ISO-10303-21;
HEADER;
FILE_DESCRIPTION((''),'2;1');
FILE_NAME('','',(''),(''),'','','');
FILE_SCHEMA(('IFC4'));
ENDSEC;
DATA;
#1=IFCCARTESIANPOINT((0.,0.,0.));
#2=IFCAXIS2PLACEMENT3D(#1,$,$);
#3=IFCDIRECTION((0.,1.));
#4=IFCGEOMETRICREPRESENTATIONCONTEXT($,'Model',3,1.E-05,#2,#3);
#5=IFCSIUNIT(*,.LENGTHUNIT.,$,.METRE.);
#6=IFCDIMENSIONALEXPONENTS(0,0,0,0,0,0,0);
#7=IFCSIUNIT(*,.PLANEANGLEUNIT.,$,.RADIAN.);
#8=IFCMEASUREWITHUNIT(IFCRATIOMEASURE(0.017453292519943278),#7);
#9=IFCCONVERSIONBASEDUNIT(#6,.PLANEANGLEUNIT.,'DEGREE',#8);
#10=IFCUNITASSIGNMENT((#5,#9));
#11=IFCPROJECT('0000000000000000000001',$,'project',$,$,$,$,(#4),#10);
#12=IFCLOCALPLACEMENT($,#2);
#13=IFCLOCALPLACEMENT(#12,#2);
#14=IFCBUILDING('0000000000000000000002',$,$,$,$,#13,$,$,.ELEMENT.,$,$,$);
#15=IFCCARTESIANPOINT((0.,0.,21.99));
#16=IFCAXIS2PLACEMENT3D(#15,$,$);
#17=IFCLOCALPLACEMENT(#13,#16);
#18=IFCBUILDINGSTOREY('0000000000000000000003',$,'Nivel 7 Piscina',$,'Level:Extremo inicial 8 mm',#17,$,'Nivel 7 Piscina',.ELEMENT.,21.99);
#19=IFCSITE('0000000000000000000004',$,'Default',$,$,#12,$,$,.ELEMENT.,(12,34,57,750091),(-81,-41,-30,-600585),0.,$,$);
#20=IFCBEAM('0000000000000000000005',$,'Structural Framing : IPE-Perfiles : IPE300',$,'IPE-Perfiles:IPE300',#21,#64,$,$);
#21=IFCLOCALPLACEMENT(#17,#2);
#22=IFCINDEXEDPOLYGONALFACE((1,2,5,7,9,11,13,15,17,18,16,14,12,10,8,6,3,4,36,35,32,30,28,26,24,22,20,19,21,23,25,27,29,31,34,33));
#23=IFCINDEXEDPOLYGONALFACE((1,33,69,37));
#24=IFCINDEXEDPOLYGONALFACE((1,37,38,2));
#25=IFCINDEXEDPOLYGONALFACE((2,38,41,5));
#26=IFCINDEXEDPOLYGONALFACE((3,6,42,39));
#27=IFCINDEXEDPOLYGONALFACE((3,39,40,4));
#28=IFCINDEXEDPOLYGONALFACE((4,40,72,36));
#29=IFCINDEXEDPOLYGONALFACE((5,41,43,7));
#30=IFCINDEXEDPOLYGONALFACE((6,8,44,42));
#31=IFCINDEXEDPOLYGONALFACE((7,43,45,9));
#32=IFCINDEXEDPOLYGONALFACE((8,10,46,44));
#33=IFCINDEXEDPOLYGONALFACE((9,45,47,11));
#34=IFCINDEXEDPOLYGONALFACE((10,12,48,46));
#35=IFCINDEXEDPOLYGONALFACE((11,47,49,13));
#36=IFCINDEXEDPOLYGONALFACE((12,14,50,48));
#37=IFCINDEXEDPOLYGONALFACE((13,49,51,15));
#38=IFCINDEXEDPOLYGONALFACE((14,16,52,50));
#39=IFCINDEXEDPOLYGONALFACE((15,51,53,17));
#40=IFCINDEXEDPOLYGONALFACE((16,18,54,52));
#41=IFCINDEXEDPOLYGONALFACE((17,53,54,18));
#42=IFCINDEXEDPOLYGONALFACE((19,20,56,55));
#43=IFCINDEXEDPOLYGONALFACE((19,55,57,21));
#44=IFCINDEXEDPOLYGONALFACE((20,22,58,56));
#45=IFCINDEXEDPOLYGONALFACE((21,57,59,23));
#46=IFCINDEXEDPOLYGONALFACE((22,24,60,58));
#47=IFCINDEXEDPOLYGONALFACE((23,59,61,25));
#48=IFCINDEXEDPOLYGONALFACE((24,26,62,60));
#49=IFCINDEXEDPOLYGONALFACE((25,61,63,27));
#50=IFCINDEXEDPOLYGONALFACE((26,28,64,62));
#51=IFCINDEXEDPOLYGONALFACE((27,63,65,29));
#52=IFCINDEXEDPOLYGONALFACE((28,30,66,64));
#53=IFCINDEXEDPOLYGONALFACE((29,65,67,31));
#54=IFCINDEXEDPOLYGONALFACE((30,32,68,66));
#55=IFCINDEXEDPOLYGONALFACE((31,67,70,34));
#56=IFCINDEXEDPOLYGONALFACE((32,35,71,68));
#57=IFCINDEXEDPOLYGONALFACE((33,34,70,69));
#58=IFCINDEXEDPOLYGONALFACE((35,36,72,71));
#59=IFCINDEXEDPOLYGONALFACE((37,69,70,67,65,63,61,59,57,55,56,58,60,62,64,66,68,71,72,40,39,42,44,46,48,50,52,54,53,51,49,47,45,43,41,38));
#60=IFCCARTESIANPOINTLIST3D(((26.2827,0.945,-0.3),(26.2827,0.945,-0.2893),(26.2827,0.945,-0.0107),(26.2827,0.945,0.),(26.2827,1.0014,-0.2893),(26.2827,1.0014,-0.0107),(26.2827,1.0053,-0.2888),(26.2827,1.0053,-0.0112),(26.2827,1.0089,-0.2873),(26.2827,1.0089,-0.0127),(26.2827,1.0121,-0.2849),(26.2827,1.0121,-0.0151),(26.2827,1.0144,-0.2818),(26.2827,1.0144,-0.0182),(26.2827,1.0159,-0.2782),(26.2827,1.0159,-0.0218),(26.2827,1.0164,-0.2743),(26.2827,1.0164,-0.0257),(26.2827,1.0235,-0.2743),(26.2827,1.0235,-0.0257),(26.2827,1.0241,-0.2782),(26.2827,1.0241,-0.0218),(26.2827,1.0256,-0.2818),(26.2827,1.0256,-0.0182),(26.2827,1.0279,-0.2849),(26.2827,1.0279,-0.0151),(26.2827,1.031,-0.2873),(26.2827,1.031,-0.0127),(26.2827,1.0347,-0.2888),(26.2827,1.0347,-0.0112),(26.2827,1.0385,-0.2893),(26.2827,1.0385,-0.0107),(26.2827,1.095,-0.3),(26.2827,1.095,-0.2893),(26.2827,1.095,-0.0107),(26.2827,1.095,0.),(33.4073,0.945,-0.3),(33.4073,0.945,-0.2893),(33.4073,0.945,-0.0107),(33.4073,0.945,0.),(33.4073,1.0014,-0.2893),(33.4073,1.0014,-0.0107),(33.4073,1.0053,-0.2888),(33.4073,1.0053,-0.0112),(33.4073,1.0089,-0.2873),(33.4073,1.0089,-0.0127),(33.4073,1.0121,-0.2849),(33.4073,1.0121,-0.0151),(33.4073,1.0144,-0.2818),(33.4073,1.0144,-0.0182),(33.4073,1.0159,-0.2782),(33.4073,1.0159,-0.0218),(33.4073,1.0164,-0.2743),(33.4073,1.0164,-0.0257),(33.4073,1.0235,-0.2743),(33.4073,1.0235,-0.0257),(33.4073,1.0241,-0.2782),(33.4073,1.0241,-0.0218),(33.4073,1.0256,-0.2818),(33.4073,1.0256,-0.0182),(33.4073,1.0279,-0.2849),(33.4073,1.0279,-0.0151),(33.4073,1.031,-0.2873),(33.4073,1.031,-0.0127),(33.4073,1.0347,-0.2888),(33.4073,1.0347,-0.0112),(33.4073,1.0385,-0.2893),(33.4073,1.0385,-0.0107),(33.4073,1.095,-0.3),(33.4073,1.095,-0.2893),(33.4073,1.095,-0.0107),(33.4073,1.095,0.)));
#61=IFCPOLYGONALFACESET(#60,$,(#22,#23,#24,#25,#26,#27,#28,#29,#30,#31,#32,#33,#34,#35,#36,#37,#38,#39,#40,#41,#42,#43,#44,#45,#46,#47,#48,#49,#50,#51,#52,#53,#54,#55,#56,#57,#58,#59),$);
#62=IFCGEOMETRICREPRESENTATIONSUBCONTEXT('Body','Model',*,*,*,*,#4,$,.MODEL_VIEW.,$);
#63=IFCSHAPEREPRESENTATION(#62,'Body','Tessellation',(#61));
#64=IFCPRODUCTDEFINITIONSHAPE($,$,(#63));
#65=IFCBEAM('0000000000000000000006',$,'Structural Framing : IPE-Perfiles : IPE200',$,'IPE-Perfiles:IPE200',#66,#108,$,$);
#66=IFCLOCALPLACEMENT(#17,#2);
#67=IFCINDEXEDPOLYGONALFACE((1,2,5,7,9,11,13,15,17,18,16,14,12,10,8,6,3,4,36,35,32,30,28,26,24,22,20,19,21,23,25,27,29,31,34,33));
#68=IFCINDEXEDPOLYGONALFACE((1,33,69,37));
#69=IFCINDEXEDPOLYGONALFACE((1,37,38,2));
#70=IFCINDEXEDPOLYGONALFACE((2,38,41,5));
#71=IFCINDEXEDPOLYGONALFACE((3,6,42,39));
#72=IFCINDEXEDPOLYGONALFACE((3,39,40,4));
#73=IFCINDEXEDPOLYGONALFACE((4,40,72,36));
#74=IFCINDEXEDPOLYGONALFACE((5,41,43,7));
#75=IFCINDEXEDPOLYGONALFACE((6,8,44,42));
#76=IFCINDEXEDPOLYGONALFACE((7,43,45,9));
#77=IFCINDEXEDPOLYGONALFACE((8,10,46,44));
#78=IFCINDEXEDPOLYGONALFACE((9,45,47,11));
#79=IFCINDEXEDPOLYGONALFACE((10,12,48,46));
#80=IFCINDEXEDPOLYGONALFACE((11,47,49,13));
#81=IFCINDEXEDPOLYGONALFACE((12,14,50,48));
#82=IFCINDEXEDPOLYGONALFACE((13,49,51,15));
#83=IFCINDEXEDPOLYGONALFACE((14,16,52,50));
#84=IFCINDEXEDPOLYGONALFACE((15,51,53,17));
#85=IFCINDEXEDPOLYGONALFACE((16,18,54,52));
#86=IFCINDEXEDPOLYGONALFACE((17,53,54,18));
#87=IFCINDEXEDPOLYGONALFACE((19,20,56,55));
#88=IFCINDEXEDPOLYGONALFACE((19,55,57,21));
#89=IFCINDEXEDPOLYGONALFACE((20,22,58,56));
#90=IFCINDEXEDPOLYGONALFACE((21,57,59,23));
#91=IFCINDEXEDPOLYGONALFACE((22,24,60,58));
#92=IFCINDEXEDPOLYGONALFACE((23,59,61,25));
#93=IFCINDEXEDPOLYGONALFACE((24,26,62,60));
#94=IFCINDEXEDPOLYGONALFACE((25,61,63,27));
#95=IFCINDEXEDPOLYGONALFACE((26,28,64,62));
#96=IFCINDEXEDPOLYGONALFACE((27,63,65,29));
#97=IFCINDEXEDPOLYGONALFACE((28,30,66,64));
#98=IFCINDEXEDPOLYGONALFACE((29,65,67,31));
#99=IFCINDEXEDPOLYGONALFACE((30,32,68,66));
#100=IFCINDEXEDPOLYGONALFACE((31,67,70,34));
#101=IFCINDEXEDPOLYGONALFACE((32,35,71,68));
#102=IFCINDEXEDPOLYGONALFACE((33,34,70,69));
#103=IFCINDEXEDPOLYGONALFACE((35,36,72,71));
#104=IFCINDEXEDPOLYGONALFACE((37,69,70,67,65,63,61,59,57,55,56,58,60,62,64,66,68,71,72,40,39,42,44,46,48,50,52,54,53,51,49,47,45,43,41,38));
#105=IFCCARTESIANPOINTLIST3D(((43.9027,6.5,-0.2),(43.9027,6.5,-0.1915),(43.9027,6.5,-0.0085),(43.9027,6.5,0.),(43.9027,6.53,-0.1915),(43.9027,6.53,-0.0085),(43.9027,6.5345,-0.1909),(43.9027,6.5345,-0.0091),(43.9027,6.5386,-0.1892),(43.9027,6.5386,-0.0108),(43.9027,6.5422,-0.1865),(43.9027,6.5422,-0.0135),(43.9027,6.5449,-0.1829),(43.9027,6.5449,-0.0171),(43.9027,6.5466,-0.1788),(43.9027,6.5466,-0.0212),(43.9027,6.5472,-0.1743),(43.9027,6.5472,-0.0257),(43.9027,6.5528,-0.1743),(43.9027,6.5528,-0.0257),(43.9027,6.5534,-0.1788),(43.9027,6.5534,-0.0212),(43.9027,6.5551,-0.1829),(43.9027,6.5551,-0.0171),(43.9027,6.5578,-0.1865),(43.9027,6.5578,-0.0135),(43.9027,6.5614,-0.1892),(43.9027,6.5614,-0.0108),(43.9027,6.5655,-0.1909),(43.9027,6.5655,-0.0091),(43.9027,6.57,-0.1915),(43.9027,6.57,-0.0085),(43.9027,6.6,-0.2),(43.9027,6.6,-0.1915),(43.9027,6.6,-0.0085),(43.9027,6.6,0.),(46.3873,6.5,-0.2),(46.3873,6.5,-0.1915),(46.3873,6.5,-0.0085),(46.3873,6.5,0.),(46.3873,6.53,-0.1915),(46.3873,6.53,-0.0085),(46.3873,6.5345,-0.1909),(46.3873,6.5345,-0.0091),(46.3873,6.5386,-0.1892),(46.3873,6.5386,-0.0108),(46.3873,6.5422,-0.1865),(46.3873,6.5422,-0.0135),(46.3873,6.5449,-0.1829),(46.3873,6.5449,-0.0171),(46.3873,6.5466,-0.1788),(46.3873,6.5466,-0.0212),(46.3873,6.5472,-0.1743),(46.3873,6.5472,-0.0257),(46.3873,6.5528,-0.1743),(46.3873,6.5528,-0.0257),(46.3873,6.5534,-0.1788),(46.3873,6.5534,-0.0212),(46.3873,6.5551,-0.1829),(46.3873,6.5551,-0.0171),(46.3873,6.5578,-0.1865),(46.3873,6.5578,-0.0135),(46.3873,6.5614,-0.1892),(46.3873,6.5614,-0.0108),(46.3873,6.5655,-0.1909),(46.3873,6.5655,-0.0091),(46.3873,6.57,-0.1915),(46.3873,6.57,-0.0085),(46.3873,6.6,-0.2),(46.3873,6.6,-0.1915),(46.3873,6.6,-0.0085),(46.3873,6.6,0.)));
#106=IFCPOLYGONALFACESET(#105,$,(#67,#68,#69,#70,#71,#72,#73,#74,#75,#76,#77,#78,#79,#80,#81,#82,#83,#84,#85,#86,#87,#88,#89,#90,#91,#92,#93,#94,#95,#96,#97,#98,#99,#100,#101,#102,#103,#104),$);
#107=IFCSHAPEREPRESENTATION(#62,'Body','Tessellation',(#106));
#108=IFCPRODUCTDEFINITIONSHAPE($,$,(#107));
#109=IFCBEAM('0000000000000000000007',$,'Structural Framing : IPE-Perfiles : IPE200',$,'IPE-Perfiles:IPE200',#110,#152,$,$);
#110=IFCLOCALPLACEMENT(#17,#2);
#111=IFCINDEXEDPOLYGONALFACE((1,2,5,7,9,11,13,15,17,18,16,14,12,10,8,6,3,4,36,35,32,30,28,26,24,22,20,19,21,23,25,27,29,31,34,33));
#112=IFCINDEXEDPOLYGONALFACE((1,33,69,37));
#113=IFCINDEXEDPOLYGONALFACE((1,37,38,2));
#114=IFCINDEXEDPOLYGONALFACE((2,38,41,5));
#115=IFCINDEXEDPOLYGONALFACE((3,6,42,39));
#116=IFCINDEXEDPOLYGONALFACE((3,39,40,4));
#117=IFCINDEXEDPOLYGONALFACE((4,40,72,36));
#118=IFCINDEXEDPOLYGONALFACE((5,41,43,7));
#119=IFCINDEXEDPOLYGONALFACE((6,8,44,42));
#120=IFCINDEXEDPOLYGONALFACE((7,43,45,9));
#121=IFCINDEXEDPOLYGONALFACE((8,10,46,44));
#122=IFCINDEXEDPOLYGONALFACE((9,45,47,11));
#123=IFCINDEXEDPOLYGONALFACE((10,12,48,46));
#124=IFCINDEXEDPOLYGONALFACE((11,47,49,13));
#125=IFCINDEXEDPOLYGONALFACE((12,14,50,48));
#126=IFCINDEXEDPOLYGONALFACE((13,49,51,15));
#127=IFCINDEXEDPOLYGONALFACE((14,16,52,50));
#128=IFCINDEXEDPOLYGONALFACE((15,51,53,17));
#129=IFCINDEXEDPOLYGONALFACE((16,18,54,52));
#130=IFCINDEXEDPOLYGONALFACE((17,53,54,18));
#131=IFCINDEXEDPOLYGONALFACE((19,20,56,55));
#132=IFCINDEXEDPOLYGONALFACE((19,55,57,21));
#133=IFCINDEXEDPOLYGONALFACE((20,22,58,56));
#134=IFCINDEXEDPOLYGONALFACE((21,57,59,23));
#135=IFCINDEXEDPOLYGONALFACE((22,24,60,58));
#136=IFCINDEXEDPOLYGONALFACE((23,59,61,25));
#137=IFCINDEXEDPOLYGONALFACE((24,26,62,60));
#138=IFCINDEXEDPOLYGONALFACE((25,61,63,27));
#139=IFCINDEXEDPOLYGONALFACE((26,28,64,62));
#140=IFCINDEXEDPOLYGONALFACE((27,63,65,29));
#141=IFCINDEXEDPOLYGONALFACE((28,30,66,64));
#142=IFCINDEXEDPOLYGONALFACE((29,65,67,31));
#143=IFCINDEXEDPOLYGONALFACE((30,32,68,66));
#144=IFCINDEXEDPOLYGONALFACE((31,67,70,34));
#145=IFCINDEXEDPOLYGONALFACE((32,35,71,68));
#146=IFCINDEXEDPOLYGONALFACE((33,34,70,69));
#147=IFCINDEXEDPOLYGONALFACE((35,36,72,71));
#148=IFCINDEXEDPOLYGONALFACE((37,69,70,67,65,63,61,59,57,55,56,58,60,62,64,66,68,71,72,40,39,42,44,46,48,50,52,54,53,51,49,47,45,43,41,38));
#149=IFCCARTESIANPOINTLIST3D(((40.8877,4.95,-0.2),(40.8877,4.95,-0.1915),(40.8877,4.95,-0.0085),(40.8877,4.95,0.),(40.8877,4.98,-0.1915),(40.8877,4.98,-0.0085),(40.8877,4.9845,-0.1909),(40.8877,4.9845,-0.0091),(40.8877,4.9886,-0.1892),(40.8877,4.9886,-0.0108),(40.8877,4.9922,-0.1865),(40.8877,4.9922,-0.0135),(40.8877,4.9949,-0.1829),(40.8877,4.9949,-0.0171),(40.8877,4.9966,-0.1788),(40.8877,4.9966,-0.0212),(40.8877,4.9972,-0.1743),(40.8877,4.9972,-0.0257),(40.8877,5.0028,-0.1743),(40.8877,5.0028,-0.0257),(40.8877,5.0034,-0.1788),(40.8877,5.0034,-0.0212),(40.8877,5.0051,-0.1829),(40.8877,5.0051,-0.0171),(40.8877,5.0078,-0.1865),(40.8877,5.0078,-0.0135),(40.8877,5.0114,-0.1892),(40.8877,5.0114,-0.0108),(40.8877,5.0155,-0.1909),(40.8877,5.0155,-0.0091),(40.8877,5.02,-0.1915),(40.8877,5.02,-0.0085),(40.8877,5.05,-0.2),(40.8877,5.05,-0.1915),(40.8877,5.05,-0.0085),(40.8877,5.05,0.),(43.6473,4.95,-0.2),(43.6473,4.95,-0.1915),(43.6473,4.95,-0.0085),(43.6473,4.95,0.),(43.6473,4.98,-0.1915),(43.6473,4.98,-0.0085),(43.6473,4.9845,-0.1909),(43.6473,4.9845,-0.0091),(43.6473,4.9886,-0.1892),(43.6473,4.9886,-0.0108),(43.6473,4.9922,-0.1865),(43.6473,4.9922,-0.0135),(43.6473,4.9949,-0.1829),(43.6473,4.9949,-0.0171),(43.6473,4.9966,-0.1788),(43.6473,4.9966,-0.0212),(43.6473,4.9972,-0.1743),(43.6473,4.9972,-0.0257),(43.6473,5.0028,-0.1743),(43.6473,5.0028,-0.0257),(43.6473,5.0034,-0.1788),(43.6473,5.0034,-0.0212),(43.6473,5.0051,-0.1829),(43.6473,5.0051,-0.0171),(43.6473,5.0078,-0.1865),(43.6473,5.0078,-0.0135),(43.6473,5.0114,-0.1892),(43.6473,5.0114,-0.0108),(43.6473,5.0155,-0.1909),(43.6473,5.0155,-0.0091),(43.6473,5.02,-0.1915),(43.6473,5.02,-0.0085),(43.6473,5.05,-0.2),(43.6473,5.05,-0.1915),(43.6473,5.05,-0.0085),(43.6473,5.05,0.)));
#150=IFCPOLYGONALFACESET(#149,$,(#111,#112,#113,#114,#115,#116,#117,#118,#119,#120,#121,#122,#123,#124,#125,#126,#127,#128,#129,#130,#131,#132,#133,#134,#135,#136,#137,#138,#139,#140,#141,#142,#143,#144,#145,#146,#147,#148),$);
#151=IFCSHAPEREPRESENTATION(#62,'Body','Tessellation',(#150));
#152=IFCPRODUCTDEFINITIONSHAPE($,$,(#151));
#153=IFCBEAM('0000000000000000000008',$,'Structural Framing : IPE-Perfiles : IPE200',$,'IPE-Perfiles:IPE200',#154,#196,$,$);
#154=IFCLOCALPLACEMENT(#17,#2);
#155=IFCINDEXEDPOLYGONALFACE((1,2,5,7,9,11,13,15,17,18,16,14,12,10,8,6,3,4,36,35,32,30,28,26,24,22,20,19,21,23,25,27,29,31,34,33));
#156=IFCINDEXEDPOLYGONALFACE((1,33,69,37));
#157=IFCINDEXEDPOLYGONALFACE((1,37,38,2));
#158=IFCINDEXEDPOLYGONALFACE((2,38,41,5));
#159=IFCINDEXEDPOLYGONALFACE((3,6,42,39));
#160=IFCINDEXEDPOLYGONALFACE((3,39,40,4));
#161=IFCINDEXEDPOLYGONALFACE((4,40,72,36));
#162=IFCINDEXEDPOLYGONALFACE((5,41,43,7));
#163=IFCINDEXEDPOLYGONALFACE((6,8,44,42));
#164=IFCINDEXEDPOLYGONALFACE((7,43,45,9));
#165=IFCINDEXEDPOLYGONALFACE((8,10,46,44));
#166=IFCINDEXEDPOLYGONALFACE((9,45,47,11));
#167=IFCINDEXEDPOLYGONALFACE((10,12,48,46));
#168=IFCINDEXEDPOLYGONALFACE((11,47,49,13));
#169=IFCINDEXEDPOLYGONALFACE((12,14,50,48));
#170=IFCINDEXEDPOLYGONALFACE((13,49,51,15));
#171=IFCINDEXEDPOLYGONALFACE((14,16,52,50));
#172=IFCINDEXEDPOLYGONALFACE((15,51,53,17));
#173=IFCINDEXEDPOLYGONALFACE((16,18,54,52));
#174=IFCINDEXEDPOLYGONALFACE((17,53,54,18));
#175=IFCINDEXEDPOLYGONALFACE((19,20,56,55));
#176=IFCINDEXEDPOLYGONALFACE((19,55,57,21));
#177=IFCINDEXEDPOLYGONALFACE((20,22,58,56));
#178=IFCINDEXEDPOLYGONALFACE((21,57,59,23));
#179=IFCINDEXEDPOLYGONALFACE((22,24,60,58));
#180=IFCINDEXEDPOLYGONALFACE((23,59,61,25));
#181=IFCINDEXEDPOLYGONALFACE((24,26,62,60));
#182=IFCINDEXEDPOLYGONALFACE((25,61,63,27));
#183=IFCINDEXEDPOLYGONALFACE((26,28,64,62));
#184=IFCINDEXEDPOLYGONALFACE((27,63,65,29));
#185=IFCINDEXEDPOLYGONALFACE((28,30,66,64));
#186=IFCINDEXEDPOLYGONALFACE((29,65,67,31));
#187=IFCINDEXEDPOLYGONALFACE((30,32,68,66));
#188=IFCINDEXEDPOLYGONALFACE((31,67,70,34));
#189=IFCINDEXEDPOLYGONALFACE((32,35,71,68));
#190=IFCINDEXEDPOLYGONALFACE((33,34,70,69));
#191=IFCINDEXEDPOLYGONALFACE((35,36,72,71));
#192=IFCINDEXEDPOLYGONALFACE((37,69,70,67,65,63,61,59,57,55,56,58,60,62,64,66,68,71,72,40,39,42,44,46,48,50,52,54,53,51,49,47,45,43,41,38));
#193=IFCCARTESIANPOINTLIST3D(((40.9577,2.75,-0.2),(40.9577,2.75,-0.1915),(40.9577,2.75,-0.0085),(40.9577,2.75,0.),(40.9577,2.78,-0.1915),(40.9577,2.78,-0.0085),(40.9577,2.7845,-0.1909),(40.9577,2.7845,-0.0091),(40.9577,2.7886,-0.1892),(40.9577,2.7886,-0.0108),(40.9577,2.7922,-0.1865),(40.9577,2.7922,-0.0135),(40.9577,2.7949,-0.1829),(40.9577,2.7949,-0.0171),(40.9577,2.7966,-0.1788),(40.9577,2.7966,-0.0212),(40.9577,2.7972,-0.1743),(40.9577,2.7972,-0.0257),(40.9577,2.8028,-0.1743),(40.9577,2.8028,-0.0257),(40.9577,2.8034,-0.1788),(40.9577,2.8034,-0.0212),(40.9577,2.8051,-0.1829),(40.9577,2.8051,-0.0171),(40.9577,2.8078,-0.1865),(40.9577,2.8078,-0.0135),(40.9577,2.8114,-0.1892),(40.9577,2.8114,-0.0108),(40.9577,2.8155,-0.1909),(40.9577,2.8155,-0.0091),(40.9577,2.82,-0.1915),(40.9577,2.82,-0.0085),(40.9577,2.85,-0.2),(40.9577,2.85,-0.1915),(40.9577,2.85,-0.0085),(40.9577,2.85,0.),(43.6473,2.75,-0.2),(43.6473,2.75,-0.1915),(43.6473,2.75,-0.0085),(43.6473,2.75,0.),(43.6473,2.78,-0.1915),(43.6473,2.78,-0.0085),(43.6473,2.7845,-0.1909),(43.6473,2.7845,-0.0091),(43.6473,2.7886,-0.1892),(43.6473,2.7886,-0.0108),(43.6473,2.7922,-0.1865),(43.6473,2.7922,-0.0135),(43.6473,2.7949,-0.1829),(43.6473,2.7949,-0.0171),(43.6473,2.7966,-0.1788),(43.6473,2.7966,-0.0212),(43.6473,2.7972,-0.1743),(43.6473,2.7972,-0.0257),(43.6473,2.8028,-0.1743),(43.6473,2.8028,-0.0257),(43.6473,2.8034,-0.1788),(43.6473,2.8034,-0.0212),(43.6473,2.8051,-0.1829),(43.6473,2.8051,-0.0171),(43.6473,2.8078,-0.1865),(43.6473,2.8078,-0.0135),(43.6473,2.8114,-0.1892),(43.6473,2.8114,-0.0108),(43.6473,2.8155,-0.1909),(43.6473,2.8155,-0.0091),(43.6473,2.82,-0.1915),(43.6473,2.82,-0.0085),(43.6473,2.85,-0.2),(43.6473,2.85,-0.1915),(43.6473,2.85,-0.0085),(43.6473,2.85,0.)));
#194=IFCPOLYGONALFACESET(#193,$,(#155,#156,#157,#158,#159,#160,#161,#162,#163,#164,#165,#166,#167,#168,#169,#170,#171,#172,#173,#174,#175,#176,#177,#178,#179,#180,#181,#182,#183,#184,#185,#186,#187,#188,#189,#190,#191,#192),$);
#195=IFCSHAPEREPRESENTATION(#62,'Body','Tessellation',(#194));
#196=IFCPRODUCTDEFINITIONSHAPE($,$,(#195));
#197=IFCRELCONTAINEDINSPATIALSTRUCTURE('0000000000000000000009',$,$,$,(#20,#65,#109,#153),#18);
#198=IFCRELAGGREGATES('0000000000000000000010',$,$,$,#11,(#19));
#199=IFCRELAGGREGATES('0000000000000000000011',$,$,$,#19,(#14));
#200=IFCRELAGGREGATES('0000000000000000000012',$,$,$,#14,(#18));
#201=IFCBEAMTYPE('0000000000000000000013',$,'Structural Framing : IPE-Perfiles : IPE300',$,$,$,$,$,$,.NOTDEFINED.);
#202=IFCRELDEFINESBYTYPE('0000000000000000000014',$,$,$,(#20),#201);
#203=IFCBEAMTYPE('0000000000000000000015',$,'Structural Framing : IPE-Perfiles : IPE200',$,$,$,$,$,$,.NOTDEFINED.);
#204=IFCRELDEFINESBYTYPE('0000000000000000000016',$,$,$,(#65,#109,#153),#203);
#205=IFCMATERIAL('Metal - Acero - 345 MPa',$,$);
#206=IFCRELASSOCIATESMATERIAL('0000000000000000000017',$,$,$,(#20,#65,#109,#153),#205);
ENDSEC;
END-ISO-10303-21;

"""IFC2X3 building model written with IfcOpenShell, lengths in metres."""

from ifc_helpers import new_model, entity, si_unit, converted_unit, direction, frame, frame_2d, origin, place, context, subcontext, project, spatial, i_section, extrude, material, type_object, element, save


model = new_model("IFC2X3")

# Units and contexts
model_context = context("Model", 3, precision=1e-05, world=origin(), true_north=direction((0.0, 1.0)))
body_context = subcontext(model_context, "Body", "Model", "MODEL_VIEW")
ifc_project = project(units=[si_unit("LENGTHUNIT", "METRE"), converted_unit("PLANEANGLEUNIT", "DEGREE", entity("IfcRatioMeasure", 0.017453292519943278), si_unit("PLANEANGLEUNIT", "RADIAN"), dimensions=[0, 0, 0, 0, 0, 0, 0])], contexts=[model_context])

# Site, building, storey
site_placement = place(None, origin())
site = spatial("IfcSite", under=ifc_project, at=site_placement, Name="Default", CompositionType="ELEMENT", RefLatitude=(12, 34, 57, 750091), RefLongitude=(-81, -41, -30, -600585), RefElevation=0.0)
building_placement = place(site_placement, origin())
building = spatial("IfcBuilding", under=site, at=building_placement, CompositionType="ELEMENT")
storey_placement = place(building_placement, frame((0.0, 0.0, 21.99)))
storey = spatial("IfcBuildingStorey", under=building, at=storey_placement, Name="Nivel 7 Piscina", ObjectType="Level:Extremo inicial 8 mm", LongName="Nivel 7 Piscina", CompositionType="ELEMENT", Elevation=21.99)

# Shared definitions
ifc_material = material(Name="Metal - Acero - 345 MPa")

# Beams
beam_type_1 = type_object("IfcBeamType", Name="Structural Framing : IPE-Perfiles : IPE300", PredefinedType="NOTDEFINED")
beam_1_placement = place(storey_placement, frame((26.195, 1.02, 0.0)))
element("IfcBeam", 1, at=beam_1_placement, inside=storey, type_object=beam_type_1, material=ifc_material, Name="Structural Framing : IPE-Perfiles : IPE300", ObjectType="IPE-Perfiles:IPE300", context=body_context, shape_type="SweptSolid", body=[
    extrude(i_section(OverallWidth=0.15, OverallDepth=0.3, WebThickness=0.0071, FlangeThickness=0.0107, FilletRadius=0.015, at=frame_2d((0.0, 0.0), x_axis=(0.0, 1.0))), frame((0.0877, 0.0, -0.15), z_axis=(1.0, 0.0, 0.0), x_axis=(0.0, 0.0, -1.0)), (0.0, 0.0, 1.0), 7.1246),
])
beam_type_2 = type_object("IfcBeamType", Name="Structural Framing : IPE-Perfiles : IPE200", PredefinedType="NOTDEFINED")
beam_2_placement = place(storey_placement, frame((43.74, 6.55, 0.0)))
element("IfcBeam", 2, at=beam_2_placement, inside=storey, type_object=beam_type_2, material=ifc_material, Name="Structural Framing : IPE-Perfiles : IPE200", ObjectType="IPE-Perfiles:IPE200", context=body_context, shape_type="SweptSolid", body=[
    extrude(i_section(OverallWidth=0.1, OverallDepth=0.2, WebThickness=0.0056, FlangeThickness=0.0085, FilletRadius=0.0172, at=frame_2d((0.0, 0.0), x_axis=(0.0, 1.0))), frame((0.1627, 0.0, -0.1), z_axis=(1.0, 0.0, 0.0), x_axis=(0.0, 0.0, -1.0)), (0.0, 0.0, 1.0), 2.4846),
])
beam_3_placement = place(storey_placement, frame((40.795, 5.0, 0.0)))
element("IfcBeam", 3, at=beam_3_placement, inside=storey, type_object=beam_type_2, material=ifc_material, Name="Structural Framing : IPE-Perfiles : IPE200", ObjectType="IPE-Perfiles:IPE200", context=body_context, shape_type="SweptSolid", body=[
    extrude(i_section(OverallWidth=0.1, OverallDepth=0.2, WebThickness=0.0056, FlangeThickness=0.0085, FilletRadius=0.0172, at=frame_2d((0.0, 0.0), x_axis=(0.0, 1.0))), frame((0.0927, 0.0, -0.1), z_axis=(1.0, 0.0, 0.0), x_axis=(0.0, 0.0, -1.0)), (0.0, 0.0, 1.0), 2.7596),
])
beam_4_placement = place(storey_placement, frame((40.795, 2.8, 0.0)))
element("IfcBeam", 4, at=beam_4_placement, inside=storey, type_object=beam_type_2, material=ifc_material, Name="Structural Framing : IPE-Perfiles : IPE200", ObjectType="IPE-Perfiles:IPE200", context=body_context, shape_type="SweptSolid", body=[
    extrude(i_section(OverallWidth=0.1, OverallDepth=0.2, WebThickness=0.0056, FlangeThickness=0.0085, FilletRadius=0.0172, at=frame_2d((0.0, 0.0), x_axis=(0.0, 1.0))), frame((0.1627, 0.0, -0.1), z_axis=(1.0, 0.0, 0.0), x_axis=(0.0, 0.0, -1.0)), (0.0, 0.0, 1.0), 2.6896),
])

save(model, "model.ifc")
